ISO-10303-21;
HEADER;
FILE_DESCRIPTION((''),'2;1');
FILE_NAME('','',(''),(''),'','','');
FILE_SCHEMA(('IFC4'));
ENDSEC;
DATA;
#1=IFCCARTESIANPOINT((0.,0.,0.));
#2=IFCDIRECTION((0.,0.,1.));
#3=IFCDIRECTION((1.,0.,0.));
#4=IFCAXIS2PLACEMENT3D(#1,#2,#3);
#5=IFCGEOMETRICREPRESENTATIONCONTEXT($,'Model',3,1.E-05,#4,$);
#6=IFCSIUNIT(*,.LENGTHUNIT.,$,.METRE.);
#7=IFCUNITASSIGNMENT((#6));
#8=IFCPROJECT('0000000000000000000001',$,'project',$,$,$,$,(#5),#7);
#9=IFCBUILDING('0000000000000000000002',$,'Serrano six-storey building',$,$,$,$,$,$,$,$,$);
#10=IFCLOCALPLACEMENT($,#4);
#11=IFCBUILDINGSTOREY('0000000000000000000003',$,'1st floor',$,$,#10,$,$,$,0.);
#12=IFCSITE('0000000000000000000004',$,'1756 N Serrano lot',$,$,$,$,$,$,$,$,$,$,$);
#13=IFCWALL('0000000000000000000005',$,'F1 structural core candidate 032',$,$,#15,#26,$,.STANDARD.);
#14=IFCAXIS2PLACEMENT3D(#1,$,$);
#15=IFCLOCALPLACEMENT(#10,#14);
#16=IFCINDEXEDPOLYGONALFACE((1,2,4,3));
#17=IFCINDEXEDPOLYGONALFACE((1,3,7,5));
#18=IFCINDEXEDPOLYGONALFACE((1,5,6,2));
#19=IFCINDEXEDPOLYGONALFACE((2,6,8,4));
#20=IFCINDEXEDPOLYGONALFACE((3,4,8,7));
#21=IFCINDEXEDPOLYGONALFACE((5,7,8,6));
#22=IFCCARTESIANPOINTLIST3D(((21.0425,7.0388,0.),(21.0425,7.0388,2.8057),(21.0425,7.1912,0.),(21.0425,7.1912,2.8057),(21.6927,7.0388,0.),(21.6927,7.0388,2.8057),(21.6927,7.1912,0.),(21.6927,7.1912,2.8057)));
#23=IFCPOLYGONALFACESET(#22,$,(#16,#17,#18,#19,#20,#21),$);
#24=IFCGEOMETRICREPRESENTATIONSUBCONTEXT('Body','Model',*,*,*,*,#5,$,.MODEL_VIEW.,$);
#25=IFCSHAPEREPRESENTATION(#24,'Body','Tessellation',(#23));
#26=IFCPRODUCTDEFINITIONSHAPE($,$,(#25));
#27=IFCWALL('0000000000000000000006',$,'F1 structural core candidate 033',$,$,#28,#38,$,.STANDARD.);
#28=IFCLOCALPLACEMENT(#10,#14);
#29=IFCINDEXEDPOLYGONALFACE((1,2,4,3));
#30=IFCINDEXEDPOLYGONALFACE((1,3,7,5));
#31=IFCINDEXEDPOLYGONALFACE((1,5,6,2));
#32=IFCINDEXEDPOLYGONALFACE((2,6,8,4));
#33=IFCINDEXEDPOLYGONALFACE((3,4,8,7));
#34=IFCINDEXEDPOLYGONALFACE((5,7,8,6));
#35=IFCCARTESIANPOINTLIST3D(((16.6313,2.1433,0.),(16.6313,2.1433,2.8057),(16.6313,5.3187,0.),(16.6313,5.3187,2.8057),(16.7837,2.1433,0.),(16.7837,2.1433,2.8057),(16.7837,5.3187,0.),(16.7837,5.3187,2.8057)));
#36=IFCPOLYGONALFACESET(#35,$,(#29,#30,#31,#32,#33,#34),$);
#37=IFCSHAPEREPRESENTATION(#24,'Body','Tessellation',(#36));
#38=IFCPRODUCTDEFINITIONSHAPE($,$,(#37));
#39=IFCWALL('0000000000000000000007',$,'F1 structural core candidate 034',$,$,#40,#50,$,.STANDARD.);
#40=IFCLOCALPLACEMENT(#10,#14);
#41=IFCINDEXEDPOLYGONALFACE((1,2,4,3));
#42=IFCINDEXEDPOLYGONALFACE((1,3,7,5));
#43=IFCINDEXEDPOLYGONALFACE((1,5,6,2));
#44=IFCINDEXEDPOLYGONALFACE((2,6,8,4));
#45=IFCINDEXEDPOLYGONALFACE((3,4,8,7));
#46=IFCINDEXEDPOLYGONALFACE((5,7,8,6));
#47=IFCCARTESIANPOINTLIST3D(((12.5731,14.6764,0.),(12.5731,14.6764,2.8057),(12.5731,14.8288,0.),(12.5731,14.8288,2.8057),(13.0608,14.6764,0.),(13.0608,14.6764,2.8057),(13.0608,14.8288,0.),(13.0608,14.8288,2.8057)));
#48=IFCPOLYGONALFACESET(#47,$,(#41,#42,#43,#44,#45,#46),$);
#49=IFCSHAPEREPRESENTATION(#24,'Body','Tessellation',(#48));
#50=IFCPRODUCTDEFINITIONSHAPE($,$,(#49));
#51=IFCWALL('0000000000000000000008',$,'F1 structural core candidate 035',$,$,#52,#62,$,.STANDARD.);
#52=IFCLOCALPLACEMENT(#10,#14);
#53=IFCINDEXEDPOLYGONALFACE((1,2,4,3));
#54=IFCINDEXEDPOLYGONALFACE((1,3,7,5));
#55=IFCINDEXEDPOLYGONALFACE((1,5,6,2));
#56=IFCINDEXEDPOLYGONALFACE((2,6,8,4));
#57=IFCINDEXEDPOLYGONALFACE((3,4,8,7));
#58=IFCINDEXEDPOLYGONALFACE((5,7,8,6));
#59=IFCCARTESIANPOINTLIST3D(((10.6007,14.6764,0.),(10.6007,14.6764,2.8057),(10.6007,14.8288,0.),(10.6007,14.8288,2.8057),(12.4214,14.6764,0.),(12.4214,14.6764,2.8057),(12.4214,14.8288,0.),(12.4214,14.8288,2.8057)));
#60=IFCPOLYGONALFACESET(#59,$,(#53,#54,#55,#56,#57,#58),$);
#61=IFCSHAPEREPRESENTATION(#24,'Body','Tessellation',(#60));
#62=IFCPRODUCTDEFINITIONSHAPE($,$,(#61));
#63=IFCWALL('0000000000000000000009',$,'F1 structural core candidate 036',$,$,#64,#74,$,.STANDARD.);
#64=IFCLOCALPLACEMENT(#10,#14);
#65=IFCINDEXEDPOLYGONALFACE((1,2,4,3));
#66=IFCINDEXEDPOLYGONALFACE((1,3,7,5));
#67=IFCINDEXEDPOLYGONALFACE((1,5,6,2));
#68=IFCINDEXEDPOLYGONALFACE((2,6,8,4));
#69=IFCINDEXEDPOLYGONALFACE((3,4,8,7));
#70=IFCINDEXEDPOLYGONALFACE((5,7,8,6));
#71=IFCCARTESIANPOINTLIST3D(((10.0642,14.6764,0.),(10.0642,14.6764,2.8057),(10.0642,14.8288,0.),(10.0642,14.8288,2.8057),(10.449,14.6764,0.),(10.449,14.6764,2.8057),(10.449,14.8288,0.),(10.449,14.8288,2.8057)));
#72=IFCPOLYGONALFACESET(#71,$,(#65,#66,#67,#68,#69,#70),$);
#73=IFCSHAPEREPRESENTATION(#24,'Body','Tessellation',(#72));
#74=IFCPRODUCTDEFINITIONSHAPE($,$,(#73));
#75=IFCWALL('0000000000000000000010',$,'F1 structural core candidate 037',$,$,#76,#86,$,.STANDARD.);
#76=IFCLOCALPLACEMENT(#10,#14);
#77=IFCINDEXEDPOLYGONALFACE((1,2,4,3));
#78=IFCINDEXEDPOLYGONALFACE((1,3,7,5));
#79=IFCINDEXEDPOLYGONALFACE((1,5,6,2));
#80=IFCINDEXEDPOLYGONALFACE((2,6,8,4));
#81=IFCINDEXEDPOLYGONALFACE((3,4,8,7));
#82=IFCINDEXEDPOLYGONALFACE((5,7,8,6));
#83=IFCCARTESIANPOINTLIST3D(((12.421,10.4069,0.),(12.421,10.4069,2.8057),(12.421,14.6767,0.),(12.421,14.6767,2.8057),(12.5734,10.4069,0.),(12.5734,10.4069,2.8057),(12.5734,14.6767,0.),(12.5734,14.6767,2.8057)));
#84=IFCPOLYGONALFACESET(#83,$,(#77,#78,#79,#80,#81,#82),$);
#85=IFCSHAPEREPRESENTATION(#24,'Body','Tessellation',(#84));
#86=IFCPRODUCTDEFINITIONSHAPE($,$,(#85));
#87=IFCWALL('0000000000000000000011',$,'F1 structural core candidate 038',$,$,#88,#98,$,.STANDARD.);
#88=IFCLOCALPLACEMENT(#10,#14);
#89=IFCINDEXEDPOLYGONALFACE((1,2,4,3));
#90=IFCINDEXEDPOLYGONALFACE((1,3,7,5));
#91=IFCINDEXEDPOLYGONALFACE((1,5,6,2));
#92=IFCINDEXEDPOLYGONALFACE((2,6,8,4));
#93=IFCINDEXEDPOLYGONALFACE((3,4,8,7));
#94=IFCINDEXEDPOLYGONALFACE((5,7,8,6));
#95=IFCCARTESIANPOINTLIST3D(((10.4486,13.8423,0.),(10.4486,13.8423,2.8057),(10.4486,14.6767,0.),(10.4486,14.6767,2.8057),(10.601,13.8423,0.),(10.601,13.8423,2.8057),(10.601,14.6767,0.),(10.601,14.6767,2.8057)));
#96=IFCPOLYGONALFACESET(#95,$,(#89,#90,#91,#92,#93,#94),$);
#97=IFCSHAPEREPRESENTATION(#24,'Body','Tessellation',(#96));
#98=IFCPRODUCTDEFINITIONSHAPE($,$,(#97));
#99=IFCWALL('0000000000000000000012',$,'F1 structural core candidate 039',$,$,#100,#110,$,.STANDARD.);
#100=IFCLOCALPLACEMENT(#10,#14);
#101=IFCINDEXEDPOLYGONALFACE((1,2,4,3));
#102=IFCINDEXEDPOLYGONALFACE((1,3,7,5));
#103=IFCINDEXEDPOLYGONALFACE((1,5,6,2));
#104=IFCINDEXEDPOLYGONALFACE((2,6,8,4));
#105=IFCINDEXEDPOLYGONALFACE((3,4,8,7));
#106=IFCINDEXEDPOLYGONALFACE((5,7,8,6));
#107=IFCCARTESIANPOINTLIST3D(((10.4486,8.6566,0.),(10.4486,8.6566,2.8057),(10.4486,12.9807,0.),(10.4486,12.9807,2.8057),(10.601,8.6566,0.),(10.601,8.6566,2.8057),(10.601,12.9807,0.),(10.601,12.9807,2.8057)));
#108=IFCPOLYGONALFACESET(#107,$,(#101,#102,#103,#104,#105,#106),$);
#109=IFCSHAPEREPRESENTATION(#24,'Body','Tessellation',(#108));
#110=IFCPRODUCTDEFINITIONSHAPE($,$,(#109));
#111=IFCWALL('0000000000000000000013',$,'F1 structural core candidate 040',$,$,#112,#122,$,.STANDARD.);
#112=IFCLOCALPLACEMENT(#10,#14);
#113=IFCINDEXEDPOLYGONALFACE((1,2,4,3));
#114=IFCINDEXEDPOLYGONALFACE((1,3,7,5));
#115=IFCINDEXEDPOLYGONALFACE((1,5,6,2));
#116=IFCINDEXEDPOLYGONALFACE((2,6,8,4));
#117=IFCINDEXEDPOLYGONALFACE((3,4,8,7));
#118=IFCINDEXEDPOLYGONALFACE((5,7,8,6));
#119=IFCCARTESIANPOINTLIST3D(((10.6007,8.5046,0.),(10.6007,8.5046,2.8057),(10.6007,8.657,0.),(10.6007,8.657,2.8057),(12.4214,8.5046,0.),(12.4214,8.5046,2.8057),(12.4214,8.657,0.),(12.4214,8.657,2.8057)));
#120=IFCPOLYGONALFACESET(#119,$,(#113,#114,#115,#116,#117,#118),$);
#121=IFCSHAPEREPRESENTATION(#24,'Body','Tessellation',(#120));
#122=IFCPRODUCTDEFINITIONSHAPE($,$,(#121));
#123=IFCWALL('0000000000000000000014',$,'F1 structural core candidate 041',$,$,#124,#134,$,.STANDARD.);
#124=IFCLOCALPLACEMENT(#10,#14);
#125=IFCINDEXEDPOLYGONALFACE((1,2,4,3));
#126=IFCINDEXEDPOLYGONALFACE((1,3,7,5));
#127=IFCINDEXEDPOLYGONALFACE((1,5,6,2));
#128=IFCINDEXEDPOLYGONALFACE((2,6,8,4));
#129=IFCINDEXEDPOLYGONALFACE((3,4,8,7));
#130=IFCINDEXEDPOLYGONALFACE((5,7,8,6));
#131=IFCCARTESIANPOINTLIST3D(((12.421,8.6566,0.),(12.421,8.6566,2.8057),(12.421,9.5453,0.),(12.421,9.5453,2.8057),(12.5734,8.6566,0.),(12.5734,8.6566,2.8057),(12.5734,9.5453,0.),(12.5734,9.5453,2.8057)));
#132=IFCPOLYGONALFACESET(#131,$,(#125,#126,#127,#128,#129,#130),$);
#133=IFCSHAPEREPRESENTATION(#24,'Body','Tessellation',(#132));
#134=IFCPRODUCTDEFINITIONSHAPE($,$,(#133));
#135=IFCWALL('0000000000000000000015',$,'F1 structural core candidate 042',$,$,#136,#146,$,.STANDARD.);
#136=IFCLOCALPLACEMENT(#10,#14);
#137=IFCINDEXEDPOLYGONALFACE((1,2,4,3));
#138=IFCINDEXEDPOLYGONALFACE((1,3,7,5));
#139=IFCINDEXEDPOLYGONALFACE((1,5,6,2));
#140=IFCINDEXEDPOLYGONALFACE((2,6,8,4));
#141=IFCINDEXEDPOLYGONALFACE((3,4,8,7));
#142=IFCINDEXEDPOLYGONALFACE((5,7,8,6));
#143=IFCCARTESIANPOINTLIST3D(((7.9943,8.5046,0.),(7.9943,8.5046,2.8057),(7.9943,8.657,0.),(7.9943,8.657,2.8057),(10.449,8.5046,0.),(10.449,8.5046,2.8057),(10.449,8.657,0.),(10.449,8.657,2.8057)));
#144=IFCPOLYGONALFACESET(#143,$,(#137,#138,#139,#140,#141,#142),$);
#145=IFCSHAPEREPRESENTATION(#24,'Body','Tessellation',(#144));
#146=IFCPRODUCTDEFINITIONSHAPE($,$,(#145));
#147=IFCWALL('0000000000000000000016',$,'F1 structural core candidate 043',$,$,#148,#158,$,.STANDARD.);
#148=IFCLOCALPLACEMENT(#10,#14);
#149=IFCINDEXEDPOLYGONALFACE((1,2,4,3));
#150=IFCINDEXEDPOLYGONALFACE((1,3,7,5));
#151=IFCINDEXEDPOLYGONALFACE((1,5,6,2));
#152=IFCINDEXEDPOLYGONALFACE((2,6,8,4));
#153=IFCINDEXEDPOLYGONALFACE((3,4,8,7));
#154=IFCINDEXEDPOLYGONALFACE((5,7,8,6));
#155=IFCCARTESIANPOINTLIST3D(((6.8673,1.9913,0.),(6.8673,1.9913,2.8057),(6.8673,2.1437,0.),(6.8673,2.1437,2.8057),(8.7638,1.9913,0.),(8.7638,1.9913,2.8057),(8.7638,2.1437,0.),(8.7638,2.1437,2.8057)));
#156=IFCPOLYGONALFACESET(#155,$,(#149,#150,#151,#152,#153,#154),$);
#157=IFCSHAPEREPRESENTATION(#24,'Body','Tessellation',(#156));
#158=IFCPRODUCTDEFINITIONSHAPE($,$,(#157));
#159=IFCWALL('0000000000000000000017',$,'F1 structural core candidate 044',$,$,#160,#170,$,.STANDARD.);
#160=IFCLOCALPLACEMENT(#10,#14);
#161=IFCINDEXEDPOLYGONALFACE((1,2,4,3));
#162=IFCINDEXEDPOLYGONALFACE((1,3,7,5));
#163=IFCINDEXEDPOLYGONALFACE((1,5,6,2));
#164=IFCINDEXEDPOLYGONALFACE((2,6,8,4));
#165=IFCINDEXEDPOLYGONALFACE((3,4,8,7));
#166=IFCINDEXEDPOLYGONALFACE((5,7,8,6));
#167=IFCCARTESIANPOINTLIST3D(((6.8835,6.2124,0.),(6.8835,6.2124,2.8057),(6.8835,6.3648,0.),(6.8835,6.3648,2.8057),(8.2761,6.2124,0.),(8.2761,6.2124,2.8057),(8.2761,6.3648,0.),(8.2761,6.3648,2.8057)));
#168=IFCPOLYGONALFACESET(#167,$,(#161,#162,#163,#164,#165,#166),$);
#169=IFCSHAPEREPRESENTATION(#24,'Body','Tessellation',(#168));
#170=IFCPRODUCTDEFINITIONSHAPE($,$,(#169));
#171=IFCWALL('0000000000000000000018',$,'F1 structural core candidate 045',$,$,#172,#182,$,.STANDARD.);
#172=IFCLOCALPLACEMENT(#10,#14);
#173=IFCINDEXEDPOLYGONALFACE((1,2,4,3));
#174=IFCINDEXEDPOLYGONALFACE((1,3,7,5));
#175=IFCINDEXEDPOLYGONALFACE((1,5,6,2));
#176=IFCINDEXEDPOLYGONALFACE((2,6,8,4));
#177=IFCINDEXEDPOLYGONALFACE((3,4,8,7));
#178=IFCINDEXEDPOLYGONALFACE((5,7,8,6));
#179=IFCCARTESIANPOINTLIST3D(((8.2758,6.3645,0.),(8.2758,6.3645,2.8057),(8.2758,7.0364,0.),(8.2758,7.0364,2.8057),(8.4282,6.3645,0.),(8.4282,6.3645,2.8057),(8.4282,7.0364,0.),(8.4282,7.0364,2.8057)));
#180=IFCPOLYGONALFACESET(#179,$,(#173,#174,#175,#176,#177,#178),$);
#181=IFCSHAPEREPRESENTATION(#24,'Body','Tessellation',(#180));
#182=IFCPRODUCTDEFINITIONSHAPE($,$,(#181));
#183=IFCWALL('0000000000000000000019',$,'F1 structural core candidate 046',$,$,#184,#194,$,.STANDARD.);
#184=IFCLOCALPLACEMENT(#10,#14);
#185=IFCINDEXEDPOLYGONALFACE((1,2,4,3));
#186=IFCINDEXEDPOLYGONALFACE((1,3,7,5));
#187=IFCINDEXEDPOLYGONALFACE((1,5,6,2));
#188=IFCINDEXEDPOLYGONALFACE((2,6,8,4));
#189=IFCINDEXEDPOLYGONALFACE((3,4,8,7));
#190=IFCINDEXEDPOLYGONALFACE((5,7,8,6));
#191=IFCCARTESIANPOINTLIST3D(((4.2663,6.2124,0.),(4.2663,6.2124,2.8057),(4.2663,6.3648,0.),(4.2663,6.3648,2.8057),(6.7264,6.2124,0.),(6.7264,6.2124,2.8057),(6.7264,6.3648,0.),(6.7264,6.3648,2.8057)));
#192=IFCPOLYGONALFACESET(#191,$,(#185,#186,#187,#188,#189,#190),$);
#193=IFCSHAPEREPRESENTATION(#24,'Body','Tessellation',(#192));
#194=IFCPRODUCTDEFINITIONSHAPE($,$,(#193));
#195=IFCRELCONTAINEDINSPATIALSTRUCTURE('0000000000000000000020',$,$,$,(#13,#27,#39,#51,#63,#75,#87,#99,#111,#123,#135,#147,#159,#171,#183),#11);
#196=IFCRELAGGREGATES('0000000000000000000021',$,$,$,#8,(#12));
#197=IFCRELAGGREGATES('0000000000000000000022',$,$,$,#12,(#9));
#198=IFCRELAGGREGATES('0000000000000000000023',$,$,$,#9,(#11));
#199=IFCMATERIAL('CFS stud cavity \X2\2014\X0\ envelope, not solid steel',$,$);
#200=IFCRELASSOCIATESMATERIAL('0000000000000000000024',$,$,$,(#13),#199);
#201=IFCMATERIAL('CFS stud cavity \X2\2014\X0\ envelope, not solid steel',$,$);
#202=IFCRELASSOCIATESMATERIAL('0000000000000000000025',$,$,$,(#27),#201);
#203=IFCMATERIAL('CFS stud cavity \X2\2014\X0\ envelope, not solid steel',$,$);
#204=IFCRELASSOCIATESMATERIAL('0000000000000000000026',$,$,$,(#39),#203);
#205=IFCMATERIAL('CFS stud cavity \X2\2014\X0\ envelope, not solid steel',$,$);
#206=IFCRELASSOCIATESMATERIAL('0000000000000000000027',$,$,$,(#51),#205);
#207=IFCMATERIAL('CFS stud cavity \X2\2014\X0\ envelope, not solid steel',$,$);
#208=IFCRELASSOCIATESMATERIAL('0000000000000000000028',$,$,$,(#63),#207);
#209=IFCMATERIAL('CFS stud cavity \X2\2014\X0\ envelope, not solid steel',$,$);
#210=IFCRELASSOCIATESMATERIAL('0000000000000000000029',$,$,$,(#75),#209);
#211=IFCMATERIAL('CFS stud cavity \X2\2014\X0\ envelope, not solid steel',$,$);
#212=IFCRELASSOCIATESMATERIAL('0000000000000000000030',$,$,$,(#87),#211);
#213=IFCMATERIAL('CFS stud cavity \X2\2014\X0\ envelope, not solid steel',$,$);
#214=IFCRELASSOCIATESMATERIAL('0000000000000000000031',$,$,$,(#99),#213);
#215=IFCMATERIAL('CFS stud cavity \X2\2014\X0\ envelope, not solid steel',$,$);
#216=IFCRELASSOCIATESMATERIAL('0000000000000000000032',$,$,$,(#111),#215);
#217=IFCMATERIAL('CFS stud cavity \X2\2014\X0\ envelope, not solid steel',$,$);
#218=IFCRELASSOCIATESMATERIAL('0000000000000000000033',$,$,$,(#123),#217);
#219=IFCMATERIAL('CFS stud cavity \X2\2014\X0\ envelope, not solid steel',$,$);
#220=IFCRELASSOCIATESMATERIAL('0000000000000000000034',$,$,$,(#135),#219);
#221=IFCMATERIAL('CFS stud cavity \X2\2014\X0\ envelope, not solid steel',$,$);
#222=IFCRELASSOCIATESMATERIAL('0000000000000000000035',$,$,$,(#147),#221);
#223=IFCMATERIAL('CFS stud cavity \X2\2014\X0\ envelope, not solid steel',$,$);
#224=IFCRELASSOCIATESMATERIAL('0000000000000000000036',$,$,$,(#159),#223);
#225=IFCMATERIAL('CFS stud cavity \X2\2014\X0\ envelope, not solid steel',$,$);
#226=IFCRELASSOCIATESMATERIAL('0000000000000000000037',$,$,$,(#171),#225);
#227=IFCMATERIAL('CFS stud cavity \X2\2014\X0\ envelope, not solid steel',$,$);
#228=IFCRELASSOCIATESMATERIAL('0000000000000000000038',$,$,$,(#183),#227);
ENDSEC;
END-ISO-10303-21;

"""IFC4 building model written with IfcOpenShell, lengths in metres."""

from ifc_helpers import new_model, si_unit, origin, origin_with_axes, place, context, subcontext, project, spatial, polyline, outline, extrude, material, element, save


model = new_model("IFC4")

# Units and contexts
model_context = context("Model", 3, precision=1e-05, world=origin_with_axes())
body_context = subcontext(model_context, "Body", "Model", "MODEL_VIEW")
ifc_project = project(units=[si_unit("LENGTHUNIT", "METRE")], contexts=[model_context])

# Site, building, storey
site = spatial("IfcSite", under=ifc_project, Name="1756 N Serrano lot")
building = spatial("IfcBuilding", under=site, Name="Serrano six-storey building")
storey_placement = place(None, origin_with_axes())
storey = spatial("IfcBuildingStorey", under=building, at=storey_placement, Name="1st floor", Elevation=0.0)

# Walls
ifc_material_1 = material(Name="CFS stud cavity — envelope, not solid steel")
wall_1_placement = place(storey_placement, origin_with_axes())
element("IfcWall", 1, at=wall_1_placement, inside=storey, material=ifc_material_1, Name="F1 structural core candidate 032", PredefinedType="STANDARD", context=body_context, shape_type="SweptSolid", body=[
    extrude(outline(polyline([(21.6927, 7.1912), (21.6927, 7.0388), (21.0425, 7.0388), (21.0425, 7.1912), (21.6927, 7.1912)])), origin(), (0.0, 0.0, 1.0), 2.8057),
])
ifc_material_2 = material(Name="CFS stud cavity — envelope, not solid steel")
wall_2_placement = place(storey_placement, origin_with_axes())
element("IfcWall", 2, at=wall_2_placement, inside=storey, material=ifc_material_2, Name="F1 structural core candidate 033", PredefinedType="STANDARD", context=body_context, shape_type="SweptSolid", body=[
    extrude(outline(polyline([(16.7837, 2.1433), (16.6313, 2.1433), (16.6313, 5.3187), (16.7837, 5.3187), (16.7837, 2.1433)])), origin(), (0.0, 0.0, 1.0), 2.8057),
])
ifc_material_3 = material(Name="CFS stud cavity — envelope, not solid steel")
wall_3_placement = place(storey_placement, origin_with_axes())
element("IfcWall", 3, at=wall_3_placement, inside=storey, material=ifc_material_3, Name="F1 structural core candidate 034", PredefinedType="STANDARD", context=body_context, shape_type="SweptSolid", body=[
    extrude(outline(polyline([(13.0608, 14.8288), (13.0608, 14.6764), (12.5731, 14.6764), (12.5731, 14.8288), (13.0608, 14.8288)])), origin(), (0.0, 0.0, 1.0), 2.8057),
])
ifc_material_4 = material(Name="CFS stud cavity — envelope, not solid steel")
wall_4_placement = place(storey_placement, origin_with_axes())
element("IfcWall", 4, at=wall_4_placement, inside=storey, material=ifc_material_4, Name="F1 structural core candidate 035", PredefinedType="STANDARD", context=body_context, shape_type="SweptSolid", body=[
    extrude(outline(polyline([(12.4214, 14.8288), (12.4214, 14.6764), (10.6007, 14.6764), (10.6007, 14.8288), (12.4214, 14.8288)])), origin(), (0.0, 0.0, 1.0), 2.8057),
])
ifc_material_5 = material(Name="CFS stud cavity — envelope, not solid steel")
wall_5_placement = place(storey_placement, origin_with_axes())
element("IfcWall", 5, at=wall_5_placement, inside=storey, material=ifc_material_5, Name="F1 structural core candidate 036", PredefinedType="STANDARD", context=body_context, shape_type="SweptSolid", body=[
    extrude(outline(polyline([(10.449, 14.8288), (10.449, 14.6764), (10.0642, 14.6764), (10.0642, 14.8288), (10.449, 14.8288)])), origin(), (0.0, 0.0, 1.0), 2.8057),
])
ifc_material_6 = material(Name="CFS stud cavity — envelope, not solid steel")
wall_6_placement = place(storey_placement, origin_with_axes())
element("IfcWall", 6, at=wall_6_placement, inside=storey, material=ifc_material_6, Name="F1 structural core candidate 037", PredefinedType="STANDARD", context=body_context, shape_type="SweptSolid", body=[
    extrude(outline(polyline([(12.5734, 10.4069), (12.421, 10.4069), (12.421, 14.6767), (12.5734, 14.6767), (12.5734, 10.4069)])), origin(), (0.0, 0.0, 1.0), 2.8057),
])
ifc_material_7 = material(Name="CFS stud cavity — envelope, not solid steel")
wall_7_placement = place(storey_placement, origin_with_axes())
element("IfcWall", 7, at=wall_7_placement, inside=storey, material=ifc_material_7, Name="F1 structural core candidate 038", PredefinedType="STANDARD", context=body_context, shape_type="SweptSolid", body=[
    extrude(outline(polyline([(10.601, 13.8423), (10.4486, 13.8423), (10.4486, 14.6767), (10.601, 14.6767), (10.601, 13.8423)])), origin(), (0.0, 0.0, 1.0), 2.8057),
])
ifc_material_8 = material(Name="CFS stud cavity — envelope, not solid steel")
wall_8_placement = place(storey_placement, origin_with_axes())
element("IfcWall", 8, at=wall_8_placement, inside=storey, material=ifc_material_8, Name="F1 structural core candidate 039", PredefinedType="STANDARD", context=body_context, shape_type="SweptSolid", body=[
    extrude(outline(polyline([(10.601, 8.6566), (10.4486, 8.6566), (10.4486, 12.9807), (10.601, 12.9807), (10.601, 8.6566)])), origin(), (0.0, 0.0, 1.0), 2.8057),
])
ifc_material_9 = material(Name="CFS stud cavity — envelope, not solid steel")
wall_9_placement = place(storey_placement, origin_with_axes())
element("IfcWall", 9, at=wall_9_placement, inside=storey, material=ifc_material_9, Name="F1 structural core candidate 040", PredefinedType="STANDARD", context=body_context, shape_type="SweptSolid", body=[
    extrude(outline(polyline([(12.4214, 8.657), (12.4214, 8.5046), (10.6007, 8.5046), (10.6007, 8.657), (12.4214, 8.657)])), origin(), (0.0, 0.0, 1.0), 2.8057),
])
ifc_material_10 = material(Name="CFS stud cavity — envelope, not solid steel")
wall_10_placement = place(storey_placement, origin_with_axes())
element("IfcWall", 10, at=wall_10_placement, inside=storey, material=ifc_material_10, Name="F1 structural core candidate 041", PredefinedType="STANDARD", context=body_context, shape_type="SweptSolid", body=[
    extrude(outline(polyline([(12.5734, 8.6566), (12.421, 8.6566), (12.421, 9.5453), (12.5734, 9.5453), (12.5734, 8.6566)])), origin(), (0.0, 0.0, 1.0), 2.8057),
])
ifc_material_11 = material(Name="CFS stud cavity — envelope, not solid steel")
wall_11_placement = place(storey_placement, origin_with_axes())
element("IfcWall", 11, at=wall_11_placement, inside=storey, material=ifc_material_11, Name="F1 structural core candidate 042", PredefinedType="STANDARD", context=body_context, shape_type="SweptSolid", body=[
    extrude(outline(polyline([(10.449, 8.657), (10.449, 8.5046), (7.9943, 8.5046), (7.9943, 8.657), (10.449, 8.657)])), origin(), (0.0, 0.0, 1.0), 2.8057),
])
ifc_material_12 = material(Name="CFS stud cavity — envelope, not solid steel")
wall_12_placement = place(storey_placement, origin_with_axes())
element("IfcWall", 12, at=wall_12_placement, inside=storey, material=ifc_material_12, Name="F1 structural core candidate 043", PredefinedType="STANDARD", context=body_context, shape_type="SweptSolid", body=[
    extrude(outline(polyline([(8.7638, 2.1437), (8.7638, 1.9913), (6.8673, 1.9913), (6.8673, 2.1437), (8.7638, 2.1437)])), origin(), (0.0, 0.0, 1.0), 2.8057),
])
ifc_material_13 = material(Name="CFS stud cavity — envelope, not solid steel")
wall_13_placement = place(storey_placement, origin_with_axes())
element("IfcWall", 13, at=wall_13_placement, inside=storey, material=ifc_material_13, Name="F1 structural core candidate 044", PredefinedType="STANDARD", context=body_context, shape_type="SweptSolid", body=[
    extrude(outline(polyline([(8.2761, 6.3648), (8.2761, 6.2124), (6.8835, 6.2124), (6.8835, 6.3648), (8.2761, 6.3648)])), origin(), (0.0, 0.0, 1.0), 2.8057),
])
ifc_material_14 = material(Name="CFS stud cavity — envelope, not solid steel")
wall_14_placement = place(storey_placement, origin_with_axes())
element("IfcWall", 14, at=wall_14_placement, inside=storey, material=ifc_material_14, Name="F1 structural core candidate 045", PredefinedType="STANDARD", context=body_context, shape_type="SweptSolid", body=[
    extrude(outline(polyline([(8.4282, 6.3645), (8.2758, 6.3645), (8.2758, 7.0364), (8.4282, 7.0364), (8.4282, 6.3645)])), origin(), (0.0, 0.0, 1.0), 2.8057),
])
ifc_material_15 = material(Name="CFS stud cavity — envelope, not solid steel")
wall_15_placement = place(storey_placement, origin_with_axes())
element("IfcWall", 15, at=wall_15_placement, inside=storey, material=ifc_material_15, Name="F1 structural core candidate 046", PredefinedType="STANDARD", context=body_context, shape_type="SweptSolid", body=[
    extrude(outline(polyline([(6.7264, 6.3648), (6.7264, 6.2124), (4.2663, 6.2124), (4.2663, 6.3648), (6.7264, 6.3648)])), origin(), (0.0, 0.0, 1.0), 2.8057),
])

save(model, "model.ifc")
